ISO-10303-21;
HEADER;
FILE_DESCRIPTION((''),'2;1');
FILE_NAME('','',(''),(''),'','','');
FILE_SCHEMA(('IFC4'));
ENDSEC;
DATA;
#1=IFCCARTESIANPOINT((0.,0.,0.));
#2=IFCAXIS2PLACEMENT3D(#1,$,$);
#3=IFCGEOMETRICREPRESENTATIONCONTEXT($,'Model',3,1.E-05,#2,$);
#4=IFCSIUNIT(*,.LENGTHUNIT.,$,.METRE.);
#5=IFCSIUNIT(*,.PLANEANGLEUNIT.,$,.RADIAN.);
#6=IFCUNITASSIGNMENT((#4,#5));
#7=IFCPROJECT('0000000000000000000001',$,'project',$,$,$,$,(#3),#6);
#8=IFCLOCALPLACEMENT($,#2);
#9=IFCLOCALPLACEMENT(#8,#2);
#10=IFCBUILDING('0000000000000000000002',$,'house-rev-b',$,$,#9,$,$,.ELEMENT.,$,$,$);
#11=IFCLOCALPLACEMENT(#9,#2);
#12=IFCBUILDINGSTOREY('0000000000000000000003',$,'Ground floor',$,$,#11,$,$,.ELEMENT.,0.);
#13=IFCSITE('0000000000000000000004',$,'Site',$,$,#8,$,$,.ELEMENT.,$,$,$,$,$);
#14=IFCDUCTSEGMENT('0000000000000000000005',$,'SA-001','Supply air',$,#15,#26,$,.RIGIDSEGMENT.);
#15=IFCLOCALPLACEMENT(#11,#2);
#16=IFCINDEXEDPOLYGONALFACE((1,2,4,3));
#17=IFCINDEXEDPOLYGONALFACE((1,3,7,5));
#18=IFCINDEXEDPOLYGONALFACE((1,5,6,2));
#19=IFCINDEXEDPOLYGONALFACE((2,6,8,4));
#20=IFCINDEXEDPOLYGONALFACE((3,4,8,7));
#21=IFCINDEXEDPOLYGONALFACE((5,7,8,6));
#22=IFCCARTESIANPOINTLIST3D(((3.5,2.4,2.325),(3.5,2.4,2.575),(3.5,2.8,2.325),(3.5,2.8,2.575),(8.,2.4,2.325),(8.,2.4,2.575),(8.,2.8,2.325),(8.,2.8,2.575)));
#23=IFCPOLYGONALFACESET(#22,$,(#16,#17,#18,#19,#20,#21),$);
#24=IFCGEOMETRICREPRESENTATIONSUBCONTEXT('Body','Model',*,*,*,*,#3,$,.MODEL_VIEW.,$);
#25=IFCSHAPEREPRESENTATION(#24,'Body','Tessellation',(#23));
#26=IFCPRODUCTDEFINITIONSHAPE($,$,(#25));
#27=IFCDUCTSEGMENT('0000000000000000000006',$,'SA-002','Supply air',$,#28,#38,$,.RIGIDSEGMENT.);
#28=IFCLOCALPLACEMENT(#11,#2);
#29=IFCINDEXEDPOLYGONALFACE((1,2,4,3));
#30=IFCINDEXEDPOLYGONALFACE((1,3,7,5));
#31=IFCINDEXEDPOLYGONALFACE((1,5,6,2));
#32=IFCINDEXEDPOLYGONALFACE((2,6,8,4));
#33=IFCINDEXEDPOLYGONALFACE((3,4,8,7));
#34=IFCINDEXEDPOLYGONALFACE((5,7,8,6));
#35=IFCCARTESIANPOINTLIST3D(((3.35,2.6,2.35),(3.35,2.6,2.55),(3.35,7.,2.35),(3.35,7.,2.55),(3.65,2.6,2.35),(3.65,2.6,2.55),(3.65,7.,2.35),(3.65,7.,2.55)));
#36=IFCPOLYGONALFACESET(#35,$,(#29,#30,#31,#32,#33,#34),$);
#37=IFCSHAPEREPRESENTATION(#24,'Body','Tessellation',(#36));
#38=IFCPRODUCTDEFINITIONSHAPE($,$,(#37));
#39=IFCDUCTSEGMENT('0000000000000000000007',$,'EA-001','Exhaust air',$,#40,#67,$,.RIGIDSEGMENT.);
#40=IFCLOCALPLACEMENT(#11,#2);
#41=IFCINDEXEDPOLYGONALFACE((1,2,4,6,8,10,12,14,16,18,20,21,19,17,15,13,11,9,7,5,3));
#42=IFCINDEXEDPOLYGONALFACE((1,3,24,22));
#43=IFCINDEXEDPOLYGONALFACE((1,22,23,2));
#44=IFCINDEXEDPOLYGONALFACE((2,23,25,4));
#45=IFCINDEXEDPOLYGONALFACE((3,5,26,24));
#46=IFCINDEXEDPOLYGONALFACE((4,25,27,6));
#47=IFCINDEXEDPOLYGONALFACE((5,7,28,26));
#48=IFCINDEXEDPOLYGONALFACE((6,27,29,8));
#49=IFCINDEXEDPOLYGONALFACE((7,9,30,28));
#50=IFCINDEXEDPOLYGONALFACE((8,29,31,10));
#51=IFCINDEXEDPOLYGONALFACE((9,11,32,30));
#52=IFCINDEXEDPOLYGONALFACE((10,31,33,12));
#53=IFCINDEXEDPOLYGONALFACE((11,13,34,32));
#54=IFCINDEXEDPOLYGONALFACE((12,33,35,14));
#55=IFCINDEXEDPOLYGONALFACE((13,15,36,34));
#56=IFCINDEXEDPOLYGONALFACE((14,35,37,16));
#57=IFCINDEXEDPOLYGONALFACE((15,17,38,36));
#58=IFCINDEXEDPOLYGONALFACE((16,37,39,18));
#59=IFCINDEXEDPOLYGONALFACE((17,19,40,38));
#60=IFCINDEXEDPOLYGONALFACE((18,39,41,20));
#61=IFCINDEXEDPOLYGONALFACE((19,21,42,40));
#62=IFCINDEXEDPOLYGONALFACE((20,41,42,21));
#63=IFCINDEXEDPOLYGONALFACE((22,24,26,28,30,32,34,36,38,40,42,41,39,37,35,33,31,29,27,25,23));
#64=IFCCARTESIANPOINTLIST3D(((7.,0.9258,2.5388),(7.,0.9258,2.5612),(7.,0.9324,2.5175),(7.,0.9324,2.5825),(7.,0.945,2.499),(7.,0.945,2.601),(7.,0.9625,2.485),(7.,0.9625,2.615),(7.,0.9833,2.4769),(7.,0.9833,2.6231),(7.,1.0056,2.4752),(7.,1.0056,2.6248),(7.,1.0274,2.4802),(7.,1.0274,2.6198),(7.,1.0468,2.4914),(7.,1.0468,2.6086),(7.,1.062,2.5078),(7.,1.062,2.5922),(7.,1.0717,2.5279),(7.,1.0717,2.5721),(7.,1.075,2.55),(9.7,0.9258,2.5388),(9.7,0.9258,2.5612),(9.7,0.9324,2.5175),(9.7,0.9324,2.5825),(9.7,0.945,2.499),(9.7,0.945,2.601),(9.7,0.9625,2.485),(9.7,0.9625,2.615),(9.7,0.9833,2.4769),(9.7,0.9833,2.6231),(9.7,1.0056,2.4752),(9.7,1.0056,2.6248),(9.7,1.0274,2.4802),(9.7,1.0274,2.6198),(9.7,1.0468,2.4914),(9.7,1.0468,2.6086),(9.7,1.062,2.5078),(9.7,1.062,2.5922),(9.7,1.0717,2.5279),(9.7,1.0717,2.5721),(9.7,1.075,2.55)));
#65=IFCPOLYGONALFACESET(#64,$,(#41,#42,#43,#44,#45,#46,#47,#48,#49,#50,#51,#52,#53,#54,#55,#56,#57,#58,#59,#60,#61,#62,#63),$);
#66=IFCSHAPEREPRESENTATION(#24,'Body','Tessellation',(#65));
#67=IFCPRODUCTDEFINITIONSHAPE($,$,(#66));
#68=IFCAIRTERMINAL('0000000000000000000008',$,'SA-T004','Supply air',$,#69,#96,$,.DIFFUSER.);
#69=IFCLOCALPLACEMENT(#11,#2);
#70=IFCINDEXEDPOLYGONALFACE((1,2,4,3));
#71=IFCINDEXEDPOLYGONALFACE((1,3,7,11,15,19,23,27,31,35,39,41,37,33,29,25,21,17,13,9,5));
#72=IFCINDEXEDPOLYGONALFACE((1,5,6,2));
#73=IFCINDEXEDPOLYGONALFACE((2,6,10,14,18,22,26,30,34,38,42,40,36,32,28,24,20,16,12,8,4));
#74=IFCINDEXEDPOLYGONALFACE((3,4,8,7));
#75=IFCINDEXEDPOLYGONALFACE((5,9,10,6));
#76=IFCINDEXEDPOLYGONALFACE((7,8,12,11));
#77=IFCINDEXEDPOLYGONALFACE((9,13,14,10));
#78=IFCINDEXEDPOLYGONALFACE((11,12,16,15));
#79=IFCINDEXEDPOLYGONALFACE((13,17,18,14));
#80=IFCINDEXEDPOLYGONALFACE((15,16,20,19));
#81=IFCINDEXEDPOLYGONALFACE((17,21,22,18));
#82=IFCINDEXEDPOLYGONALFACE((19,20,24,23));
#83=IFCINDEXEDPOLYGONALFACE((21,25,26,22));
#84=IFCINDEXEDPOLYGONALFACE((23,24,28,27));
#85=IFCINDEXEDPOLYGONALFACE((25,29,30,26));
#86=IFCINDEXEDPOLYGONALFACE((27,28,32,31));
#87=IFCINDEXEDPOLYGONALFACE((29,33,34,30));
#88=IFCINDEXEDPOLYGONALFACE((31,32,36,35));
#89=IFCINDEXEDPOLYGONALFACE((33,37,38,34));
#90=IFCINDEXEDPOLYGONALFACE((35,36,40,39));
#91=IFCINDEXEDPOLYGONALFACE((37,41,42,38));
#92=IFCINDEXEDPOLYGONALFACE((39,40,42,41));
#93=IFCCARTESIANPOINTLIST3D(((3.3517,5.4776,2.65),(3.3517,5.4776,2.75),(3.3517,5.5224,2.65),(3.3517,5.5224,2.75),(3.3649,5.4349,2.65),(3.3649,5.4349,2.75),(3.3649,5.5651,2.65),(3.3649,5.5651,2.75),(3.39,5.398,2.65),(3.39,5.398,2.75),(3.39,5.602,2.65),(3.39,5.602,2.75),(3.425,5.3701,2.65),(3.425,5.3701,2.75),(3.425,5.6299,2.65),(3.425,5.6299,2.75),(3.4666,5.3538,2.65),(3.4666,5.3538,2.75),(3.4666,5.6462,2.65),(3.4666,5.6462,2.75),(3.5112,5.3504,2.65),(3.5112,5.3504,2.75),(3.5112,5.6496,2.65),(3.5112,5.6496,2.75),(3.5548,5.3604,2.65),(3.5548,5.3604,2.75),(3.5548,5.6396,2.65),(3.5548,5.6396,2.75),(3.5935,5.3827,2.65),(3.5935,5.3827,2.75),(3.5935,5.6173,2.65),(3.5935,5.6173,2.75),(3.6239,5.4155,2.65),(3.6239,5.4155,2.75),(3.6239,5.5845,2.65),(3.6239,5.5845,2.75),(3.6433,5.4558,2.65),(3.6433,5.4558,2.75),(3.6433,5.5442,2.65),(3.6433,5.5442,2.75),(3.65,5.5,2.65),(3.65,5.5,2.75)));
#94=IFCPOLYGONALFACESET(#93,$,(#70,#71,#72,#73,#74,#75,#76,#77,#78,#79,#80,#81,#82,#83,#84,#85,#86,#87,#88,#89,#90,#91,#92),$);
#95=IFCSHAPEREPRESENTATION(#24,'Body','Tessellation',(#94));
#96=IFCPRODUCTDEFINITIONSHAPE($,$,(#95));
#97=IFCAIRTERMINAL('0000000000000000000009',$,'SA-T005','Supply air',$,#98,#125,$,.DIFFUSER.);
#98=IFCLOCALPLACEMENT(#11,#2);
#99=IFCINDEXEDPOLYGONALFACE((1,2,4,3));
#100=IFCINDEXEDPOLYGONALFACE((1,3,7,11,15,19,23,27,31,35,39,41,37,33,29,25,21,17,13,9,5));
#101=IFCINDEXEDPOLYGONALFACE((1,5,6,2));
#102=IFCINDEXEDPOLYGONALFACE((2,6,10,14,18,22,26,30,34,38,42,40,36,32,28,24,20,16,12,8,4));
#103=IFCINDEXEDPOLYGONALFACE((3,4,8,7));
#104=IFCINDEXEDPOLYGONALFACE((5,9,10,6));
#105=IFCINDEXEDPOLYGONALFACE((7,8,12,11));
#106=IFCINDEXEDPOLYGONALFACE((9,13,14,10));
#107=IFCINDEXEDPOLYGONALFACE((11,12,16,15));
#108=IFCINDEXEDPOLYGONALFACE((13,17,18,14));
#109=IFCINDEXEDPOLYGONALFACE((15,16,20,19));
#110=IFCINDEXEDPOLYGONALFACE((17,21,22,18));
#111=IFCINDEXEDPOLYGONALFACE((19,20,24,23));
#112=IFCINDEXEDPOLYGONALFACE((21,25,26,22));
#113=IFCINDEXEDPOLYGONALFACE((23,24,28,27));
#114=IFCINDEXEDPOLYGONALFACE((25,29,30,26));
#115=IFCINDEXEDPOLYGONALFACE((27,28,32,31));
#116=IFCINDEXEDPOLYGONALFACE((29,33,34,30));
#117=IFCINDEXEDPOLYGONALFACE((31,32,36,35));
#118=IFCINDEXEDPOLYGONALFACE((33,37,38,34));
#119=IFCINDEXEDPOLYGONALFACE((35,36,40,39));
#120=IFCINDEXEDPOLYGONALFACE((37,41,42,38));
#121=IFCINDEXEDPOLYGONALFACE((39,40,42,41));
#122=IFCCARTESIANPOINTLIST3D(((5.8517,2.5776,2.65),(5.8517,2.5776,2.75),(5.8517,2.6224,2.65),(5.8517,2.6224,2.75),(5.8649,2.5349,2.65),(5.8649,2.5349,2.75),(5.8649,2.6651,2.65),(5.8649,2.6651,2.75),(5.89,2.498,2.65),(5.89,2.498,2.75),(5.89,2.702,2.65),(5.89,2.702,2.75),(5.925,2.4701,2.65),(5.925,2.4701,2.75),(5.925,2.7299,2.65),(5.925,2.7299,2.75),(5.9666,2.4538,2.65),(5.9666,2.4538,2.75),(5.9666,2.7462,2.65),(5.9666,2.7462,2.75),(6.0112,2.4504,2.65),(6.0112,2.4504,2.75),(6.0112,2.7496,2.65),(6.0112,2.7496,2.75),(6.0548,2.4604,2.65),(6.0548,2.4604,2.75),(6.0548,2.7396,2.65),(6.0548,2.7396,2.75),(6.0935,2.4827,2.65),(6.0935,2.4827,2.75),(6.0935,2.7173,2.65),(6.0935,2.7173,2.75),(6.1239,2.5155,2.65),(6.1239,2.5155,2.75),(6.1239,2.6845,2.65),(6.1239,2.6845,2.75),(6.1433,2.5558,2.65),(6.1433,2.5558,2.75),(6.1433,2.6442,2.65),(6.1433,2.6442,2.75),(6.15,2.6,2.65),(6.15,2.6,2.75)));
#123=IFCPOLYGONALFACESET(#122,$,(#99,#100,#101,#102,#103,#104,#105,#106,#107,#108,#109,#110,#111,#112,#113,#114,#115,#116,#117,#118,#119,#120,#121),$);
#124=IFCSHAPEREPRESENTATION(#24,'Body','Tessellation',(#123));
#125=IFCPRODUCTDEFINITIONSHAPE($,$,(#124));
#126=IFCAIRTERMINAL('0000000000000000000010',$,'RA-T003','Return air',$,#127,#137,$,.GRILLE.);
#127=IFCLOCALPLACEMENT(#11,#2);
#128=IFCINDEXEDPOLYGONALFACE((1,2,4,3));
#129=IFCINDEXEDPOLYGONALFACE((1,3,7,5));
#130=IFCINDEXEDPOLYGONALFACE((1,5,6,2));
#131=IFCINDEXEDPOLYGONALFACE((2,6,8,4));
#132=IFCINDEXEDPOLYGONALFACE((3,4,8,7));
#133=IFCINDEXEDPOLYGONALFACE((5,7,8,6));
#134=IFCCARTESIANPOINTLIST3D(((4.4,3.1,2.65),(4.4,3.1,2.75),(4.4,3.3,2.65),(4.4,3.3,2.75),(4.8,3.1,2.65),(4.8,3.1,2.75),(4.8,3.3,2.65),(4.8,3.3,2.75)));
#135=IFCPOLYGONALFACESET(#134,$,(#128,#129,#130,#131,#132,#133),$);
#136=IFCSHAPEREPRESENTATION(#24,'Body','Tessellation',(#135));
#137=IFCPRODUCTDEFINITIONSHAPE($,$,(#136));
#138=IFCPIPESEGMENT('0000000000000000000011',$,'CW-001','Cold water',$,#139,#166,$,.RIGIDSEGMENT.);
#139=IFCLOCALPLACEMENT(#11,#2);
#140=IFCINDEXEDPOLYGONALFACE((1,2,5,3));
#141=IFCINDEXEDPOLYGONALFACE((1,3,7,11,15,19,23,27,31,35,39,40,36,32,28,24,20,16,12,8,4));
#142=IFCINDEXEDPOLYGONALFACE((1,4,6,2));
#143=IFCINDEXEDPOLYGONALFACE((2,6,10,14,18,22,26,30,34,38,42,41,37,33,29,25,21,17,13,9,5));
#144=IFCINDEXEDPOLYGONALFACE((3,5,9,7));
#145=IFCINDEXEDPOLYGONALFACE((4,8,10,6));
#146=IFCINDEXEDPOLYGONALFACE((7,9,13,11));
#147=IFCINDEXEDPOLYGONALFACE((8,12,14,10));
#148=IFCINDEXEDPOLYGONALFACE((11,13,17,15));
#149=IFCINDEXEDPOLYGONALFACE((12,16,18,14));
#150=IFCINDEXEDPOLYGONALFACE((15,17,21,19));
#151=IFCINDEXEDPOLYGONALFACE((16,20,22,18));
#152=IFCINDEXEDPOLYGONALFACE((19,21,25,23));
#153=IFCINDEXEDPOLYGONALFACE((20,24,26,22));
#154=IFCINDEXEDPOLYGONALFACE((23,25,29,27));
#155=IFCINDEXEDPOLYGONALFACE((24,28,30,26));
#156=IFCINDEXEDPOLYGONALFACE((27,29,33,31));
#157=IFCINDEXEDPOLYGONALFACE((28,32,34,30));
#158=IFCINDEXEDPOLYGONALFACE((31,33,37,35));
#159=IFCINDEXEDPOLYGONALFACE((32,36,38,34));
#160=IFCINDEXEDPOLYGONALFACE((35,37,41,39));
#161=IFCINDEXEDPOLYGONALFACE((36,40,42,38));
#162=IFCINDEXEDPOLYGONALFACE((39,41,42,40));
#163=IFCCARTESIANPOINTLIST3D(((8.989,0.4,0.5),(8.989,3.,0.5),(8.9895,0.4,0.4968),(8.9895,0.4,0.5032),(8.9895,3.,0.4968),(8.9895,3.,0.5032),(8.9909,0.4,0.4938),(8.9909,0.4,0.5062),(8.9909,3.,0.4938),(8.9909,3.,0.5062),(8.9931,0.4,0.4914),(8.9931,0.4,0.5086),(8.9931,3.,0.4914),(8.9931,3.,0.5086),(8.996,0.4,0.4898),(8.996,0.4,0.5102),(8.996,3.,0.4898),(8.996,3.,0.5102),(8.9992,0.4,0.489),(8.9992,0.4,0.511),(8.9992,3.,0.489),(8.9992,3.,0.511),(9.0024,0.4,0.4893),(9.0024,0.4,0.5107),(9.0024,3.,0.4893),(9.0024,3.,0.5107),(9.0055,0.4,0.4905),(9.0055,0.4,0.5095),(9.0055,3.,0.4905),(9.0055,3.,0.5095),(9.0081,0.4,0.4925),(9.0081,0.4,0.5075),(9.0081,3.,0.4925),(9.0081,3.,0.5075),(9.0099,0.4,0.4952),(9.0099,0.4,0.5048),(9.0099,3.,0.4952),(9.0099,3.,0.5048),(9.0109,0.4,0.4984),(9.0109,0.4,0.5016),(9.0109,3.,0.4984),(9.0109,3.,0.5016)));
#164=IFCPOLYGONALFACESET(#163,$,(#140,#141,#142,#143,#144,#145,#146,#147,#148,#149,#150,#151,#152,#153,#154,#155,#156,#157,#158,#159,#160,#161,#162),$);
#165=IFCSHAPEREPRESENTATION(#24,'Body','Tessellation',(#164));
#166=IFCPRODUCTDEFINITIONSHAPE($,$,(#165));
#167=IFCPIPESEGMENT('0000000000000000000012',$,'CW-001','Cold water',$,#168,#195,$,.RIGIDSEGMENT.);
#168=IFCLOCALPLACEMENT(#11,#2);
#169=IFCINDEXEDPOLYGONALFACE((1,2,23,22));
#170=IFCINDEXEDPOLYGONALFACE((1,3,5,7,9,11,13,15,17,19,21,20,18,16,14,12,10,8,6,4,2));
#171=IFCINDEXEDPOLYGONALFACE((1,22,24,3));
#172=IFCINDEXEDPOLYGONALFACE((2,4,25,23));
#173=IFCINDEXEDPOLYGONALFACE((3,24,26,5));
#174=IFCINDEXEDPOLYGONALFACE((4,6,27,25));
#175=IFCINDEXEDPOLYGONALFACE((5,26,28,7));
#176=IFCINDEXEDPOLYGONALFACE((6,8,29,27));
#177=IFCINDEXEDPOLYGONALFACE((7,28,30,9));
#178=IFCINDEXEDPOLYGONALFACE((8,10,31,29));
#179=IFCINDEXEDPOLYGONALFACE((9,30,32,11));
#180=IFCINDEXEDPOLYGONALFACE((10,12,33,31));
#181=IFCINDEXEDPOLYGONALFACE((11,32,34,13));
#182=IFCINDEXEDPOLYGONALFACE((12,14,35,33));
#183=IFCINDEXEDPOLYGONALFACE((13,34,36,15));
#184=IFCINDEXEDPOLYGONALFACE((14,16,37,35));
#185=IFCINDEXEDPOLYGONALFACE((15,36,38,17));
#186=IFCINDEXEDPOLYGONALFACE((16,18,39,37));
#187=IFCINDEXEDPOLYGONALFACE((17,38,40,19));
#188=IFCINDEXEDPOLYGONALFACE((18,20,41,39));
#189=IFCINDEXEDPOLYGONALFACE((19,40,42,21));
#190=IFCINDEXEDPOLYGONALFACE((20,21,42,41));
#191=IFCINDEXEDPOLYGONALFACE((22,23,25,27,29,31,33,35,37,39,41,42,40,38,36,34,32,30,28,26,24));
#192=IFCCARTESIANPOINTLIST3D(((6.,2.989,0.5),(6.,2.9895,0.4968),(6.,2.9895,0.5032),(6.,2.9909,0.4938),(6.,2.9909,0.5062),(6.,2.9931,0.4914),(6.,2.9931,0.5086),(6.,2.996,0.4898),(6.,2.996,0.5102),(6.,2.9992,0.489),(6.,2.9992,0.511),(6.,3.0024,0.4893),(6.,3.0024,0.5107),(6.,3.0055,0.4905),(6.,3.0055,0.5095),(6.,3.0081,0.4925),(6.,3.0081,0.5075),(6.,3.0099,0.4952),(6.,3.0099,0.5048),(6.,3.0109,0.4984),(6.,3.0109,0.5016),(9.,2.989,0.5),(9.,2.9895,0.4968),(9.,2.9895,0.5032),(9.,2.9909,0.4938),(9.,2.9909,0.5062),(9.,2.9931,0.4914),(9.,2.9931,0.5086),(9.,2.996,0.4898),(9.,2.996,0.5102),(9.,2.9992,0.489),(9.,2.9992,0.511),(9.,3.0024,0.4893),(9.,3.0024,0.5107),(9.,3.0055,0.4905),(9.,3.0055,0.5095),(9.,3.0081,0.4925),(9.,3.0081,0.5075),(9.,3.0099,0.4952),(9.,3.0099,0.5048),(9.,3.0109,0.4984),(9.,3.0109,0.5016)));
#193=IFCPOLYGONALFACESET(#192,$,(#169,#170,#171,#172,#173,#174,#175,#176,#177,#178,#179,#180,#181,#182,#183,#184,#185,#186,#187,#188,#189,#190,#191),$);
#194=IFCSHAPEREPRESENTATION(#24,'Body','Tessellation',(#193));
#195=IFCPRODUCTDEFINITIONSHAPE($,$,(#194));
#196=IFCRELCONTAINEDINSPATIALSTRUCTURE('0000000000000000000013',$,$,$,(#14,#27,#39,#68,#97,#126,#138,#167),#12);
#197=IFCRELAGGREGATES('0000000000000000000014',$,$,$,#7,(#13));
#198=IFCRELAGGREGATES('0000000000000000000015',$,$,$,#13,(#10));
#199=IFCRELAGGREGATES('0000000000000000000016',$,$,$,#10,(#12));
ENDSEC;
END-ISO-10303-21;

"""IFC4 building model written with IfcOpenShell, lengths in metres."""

from ifc_helpers import new_model, si_unit, frame, origin, origin_2d, place, context, subcontext, project, spatial, rectangle, circle, extrude, element, save


model = new_model("IFC4")

# Units and contexts
model_context = context("Model", 3, precision=1e-05, world=origin())
body_context = subcontext(model_context, "Body", "Model", "MODEL_VIEW")
ifc_project = project(units=[si_unit("LENGTHUNIT", "METRE"), si_unit("PLANEANGLEUNIT", "RADIAN")], contexts=[model_context])

# Site, building, storey
site_placement = place(None, origin())
site = spatial("IfcSite", under=ifc_project, at=site_placement, Name="Site", CompositionType="ELEMENT")
building_placement = place(site_placement, origin())
building = spatial("IfcBuilding", under=site, at=building_placement, Name="house-rev-b", CompositionType="ELEMENT")
storey_placement = place(building_placement, origin())
storey = spatial("IfcBuildingStorey", under=building, at=storey_placement, Name="Ground floor", CompositionType="ELEMENT", Elevation=0.0)

# Duct segments
duct_segment_1_placement = place(storey_placement, frame((3.5, 2.6, 2.45), z_axis=(1.0, 0.0, 0.0), x_axis=(0.0, 1.0, 0.0)))
element("IfcDuctSegment", 1, at=duct_segment_1_placement, inside=storey, Name="SA-001", Description="Supply air", PredefinedType="RIGIDSEGMENT", context=body_context, shape_type="SweptSolid", body=[
    extrude(rectangle(XDim=0.4, YDim=0.25, at=origin_2d()), origin(), (0.0, 0.0, 1.0), 4.5),
])
duct_segment_2_placement = place(storey_placement, frame((3.5, 2.6, 2.45), z_axis=(0.0, 1.0, 0.0), x_axis=(-1.0, 0.0, 0.0)))
element("IfcDuctSegment", 2, at=duct_segment_2_placement, inside=storey, Name="SA-002", Description="Supply air", PredefinedType="RIGIDSEGMENT", context=body_context, shape_type="SweptSolid", body=[
    extrude(rectangle(XDim=0.3, YDim=0.2, at=origin_2d()), origin(), (0.0, 0.0, 1.0), 4.4),
])
duct_segment_3_placement = place(storey_placement, frame((7.0, 1.0, 2.55), z_axis=(1.0, 0.0, 0.0), x_axis=(0.0, 1.0, 0.0)))
element("IfcDuctSegment", 3, at=duct_segment_3_placement, inside=storey, Name="EA-001", Description="Exhaust air", PredefinedType="RIGIDSEGMENT", context=body_context, shape_type="SweptSolid", body=[
    extrude(circle(Radius=0.075, at=origin_2d()), origin(), (0.0, 0.0, 1.0), 2.7),
])

# Air terminals
for number, where, z_axis, x_axis, name in (
    (4, (3.5, 5.5, 2.65), (0.0, 0.0, 1.0), (1.0, 0.0, 0.0), "SA-T004"),
    (5, (6.0, 2.6, 2.65), (0.0, 0.0, 1.0), (1.0, 0.0, 0.0), "SA-T005"),
):
    element("IfcAirTerminal", number, at=place(storey_placement, frame(where, z_axis=z_axis, x_axis=x_axis)), inside=storey, Name=name, Description="Supply air", PredefinedType="DIFFUSER", context=body_context, shape_type="SweptSolid", body=[
        extrude(circle(Radius=0.15, at=origin_2d()), origin(), (0.0, 0.0, 1.0), 0.1),
    ])
air_terminal_placement = place(storey_placement, frame((4.6, 3.2, 2.65), z_axis=(0.0, 0.0, 1.0), x_axis=(1.0, 0.0, 0.0)))
element("IfcAirTerminal", 6, at=air_terminal_placement, inside=storey, Name="RA-T003", Description="Return air", PredefinedType="GRILLE", context=body_context, shape_type="SweptSolid", body=[
    extrude(rectangle(XDim=0.4, YDim=0.2, at=origin_2d()), origin(), (0.0, 0.0, 1.0), 0.1),
])

# Pipe segments
pipe_segment_1_placement = place(storey_placement, frame((9.0, 0.4, 0.5), z_axis=(0.0, 1.0, 0.0), x_axis=(-1.0, 0.0, 0.0)))
element("IfcPipeSegment", 7, at=pipe_segment_1_placement, inside=storey, Name="CW-001", Description="Cold water", PredefinedType="RIGIDSEGMENT", context=body_context, shape_type="SweptSolid", body=[
    extrude(circle(Radius=0.011, at=origin_2d()), origin(), (0.0, 0.0, 1.0), 2.6),
])
pipe_segment_2_placement = place(storey_placement, frame((9.0, 3.0, 0.5), z_axis=(-1.0, 0.0, 0.0), x_axis=(0.0, -1.0, 0.0)))
element("IfcPipeSegment", 8, at=pipe_segment_2_placement, inside=storey, Name="CW-001", Description="Cold water", PredefinedType="RIGIDSEGMENT", context=body_context, shape_type="SweptSolid", body=[
    extrude(circle(Radius=0.011, at=origin_2d()), origin(), (0.0, 0.0, 1.0), 3.0),
])

save(model, "model.ifc")
